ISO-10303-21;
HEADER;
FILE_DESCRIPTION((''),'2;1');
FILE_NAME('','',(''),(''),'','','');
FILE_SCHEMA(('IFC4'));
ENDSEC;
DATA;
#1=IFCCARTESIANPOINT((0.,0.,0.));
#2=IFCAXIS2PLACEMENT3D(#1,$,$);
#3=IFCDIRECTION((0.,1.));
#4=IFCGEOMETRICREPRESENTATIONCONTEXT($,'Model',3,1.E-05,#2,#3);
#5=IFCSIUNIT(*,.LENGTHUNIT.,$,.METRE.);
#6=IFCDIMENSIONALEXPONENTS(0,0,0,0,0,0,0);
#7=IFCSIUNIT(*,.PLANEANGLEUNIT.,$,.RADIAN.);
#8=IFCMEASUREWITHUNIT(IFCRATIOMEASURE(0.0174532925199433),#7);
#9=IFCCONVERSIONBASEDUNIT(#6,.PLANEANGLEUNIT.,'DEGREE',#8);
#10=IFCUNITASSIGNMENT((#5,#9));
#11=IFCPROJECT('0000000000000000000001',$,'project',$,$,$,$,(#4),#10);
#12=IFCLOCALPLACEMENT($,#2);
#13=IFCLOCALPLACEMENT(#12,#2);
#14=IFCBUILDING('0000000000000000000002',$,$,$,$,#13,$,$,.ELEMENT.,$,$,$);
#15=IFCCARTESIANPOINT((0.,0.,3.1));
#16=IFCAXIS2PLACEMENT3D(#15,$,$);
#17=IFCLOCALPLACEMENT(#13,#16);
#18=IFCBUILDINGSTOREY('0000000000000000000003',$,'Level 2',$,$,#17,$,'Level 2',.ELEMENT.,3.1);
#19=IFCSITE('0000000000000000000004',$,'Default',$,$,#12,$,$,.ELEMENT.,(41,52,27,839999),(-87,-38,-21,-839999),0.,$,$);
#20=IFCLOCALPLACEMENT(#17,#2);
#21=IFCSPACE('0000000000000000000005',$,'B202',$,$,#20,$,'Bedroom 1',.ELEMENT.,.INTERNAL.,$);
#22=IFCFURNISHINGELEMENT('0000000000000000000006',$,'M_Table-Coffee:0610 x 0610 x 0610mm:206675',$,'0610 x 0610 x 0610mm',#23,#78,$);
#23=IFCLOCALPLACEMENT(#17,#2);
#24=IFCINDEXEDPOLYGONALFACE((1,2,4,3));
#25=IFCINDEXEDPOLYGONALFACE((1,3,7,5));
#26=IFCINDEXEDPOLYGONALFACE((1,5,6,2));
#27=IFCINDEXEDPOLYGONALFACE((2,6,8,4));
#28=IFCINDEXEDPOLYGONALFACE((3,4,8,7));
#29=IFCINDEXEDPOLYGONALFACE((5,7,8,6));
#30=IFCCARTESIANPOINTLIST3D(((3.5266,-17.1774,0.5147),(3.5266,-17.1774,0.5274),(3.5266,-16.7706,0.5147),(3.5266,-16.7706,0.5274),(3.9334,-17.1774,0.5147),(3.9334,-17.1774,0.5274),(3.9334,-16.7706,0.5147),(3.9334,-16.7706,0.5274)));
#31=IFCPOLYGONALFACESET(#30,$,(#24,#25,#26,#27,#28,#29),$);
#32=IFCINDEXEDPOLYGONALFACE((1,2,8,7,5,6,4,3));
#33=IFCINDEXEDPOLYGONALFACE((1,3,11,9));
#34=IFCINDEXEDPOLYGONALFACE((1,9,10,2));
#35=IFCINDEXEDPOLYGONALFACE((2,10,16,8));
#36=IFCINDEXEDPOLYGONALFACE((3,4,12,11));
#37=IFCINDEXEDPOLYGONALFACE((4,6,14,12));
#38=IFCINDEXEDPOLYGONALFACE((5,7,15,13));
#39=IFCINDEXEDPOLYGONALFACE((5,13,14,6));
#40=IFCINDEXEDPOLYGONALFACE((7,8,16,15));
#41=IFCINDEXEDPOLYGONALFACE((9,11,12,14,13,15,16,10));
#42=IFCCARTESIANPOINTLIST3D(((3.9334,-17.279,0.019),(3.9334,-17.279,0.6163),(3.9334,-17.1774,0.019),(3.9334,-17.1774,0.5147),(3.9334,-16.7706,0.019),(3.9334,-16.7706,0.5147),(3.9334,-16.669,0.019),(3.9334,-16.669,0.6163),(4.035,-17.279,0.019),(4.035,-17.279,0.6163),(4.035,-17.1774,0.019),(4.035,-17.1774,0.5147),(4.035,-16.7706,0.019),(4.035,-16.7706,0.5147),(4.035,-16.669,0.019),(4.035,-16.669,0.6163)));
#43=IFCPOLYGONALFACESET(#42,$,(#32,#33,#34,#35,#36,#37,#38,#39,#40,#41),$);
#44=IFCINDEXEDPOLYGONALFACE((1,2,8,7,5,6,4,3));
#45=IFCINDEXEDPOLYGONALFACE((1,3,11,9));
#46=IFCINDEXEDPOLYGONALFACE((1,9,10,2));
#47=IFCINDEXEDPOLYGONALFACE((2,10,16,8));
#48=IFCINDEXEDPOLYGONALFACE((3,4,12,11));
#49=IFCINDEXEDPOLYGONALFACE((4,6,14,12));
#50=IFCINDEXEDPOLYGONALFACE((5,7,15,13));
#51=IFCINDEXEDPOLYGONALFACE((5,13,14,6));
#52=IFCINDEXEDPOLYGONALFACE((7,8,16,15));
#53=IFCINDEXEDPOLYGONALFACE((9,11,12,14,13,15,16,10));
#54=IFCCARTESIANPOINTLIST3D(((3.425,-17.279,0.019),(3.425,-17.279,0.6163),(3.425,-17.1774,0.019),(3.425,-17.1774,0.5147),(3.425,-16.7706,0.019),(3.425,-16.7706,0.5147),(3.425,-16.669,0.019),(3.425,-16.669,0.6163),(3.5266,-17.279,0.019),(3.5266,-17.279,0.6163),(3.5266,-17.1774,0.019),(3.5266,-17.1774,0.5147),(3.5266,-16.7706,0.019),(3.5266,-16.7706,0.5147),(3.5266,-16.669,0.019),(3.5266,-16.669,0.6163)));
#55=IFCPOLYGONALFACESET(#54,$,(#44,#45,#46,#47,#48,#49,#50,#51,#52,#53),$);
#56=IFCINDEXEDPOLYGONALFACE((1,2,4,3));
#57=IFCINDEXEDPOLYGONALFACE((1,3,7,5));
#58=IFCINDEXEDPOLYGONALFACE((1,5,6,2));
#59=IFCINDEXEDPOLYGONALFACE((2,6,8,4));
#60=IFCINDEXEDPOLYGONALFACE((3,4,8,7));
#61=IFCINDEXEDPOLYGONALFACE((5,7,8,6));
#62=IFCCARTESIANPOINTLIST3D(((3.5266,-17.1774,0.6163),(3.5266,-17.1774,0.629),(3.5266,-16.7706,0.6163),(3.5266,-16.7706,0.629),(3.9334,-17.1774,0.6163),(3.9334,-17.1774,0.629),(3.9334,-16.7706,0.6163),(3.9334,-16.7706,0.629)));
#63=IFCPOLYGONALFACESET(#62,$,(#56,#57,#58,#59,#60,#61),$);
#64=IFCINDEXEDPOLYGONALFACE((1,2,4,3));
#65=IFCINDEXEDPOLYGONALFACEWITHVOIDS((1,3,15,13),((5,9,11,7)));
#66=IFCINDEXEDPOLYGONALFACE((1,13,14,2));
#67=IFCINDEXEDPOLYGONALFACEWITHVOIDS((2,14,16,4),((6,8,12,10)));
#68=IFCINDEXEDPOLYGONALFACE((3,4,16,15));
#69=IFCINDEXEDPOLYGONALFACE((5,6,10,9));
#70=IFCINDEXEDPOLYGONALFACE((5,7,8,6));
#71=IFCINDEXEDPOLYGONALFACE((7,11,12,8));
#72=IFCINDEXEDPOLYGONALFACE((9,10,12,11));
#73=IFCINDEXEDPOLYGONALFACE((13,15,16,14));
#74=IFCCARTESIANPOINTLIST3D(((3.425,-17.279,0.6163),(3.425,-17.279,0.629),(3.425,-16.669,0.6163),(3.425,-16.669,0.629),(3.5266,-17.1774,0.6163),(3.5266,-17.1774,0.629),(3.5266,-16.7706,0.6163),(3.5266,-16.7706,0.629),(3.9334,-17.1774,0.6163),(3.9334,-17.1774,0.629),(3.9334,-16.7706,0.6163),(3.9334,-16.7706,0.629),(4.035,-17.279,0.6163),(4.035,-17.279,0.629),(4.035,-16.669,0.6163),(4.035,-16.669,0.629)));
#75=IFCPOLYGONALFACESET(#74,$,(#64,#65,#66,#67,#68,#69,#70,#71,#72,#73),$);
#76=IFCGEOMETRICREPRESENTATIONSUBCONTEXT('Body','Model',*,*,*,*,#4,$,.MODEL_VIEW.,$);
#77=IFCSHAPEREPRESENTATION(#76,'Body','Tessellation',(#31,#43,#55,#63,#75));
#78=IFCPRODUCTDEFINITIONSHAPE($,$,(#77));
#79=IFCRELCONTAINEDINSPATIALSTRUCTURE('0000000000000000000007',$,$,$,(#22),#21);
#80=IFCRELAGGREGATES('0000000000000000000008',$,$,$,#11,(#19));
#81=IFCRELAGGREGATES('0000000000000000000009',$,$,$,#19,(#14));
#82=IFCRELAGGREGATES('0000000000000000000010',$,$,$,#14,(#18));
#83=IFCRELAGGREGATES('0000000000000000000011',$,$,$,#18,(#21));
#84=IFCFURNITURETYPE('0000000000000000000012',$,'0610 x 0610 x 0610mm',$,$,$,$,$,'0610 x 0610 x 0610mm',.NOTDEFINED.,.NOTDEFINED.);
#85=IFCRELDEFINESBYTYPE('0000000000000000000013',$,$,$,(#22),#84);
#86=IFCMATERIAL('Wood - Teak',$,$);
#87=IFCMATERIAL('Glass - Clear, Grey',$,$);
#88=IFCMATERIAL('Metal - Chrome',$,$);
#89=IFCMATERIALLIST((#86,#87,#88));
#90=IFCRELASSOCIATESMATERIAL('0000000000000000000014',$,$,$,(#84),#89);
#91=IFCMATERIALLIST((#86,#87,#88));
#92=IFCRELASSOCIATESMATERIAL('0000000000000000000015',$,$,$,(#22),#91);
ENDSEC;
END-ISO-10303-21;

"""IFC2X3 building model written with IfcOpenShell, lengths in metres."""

from ifc_helpers import new_model, entity, si_unit, converted_unit, direction, frame, origin, origin_2d_with_axis, place, context, subcontext, project, spatial, polyline, rectangle, outline, extrude, source, transform, mapped, material, material_list, type_object, type_shapes, element, save


model = new_model("IFC2X3")

# Units and contexts
model_context = context("Model", 3, precision=1e-05, world=origin(), true_north=direction((0.0, 1.0)))
body_context = subcontext(model_context, "Body", "Model", "MODEL_VIEW")
ifc_project = project(units=[si_unit("LENGTHUNIT", "METRE"), converted_unit("PLANEANGLEUNIT", "DEGREE", entity("IfcRatioMeasure", 0.0174532925199433), si_unit("PLANEANGLEUNIT", "RADIAN"), dimensions=[0, 0, 0, 0, 0, 0, 0])], contexts=[model_context])

# Site, building, storey
site_placement = place(None, origin())
site = spatial("IfcSite", under=ifc_project, at=site_placement, Name="Default", CompositionType="ELEMENT", RefLatitude=(41, 52, 27, 839999), RefLongitude=(-87, -38, -21, -839999), RefElevation=0.0)
building_placement = place(site_placement, origin())
building = spatial("IfcBuilding", under=site, at=building_placement, CompositionType="ELEMENT")
storey_placement = place(building_placement, frame((0.0, 0.0, 3.1)))
storey = spatial("IfcBuildingStorey", under=building, at=storey_placement, Name="Level 2", LongName="Level 2", CompositionType="ELEMENT", Elevation=3.1)

# Shared definitions
space_placement = place(storey_placement, origin())
space = spatial("IfcSpace", under=storey, at=space_placement, Name="B202", LongName="Bedroom 1", CompositionType="ELEMENT", InteriorOrExteriorSpace="INTERNAL")

# Furnishing element
ifc_material_1 = material(Name="Wood - Teak")
ifc_material_2 = material(Name="Glass - Clear, Grey")
ifc_material_3 = material(Name="Metal - Chrome")
ifc_material_list_1 = material_list([ifc_material_1, ifc_material_2, ifc_material_3])
ifc_material_list_2 = material_list([ifc_material_1, ifc_material_2, ifc_material_3])
furniture_type_1 = type_object("IfcFurnitureType", Name="0610 x 0610 x 0610mm", ElementType="0610 x 0610 x 0610mm", AssemblyPlace="NOTDEFINED", material=ifc_material_list_2)
shared_shape_1 = source(origin(), body_context, "Body", "SweptSolid", [
    extrude(rectangle(XDim=0.4068, YDim=0.4068, at=origin_2d_with_axis()), frame((0.0183, 0.0952, 0.4957), z_axis=(0.0, 0.0, 1.0), x_axis=(-1.0, 0.0, 0.0)), (0.0, 0.0, 1.0), 0.0127),
    extrude(outline(polyline([(-0.2732, -0.305), (0.324, -0.305), (0.324, 0.305), (-0.2732, 0.305), (-0.2732, 0.2034), (0.2225, 0.2034), (0.2225, -0.2034), (-0.2732, -0.2034), (-0.2732, -0.305)])), frame((0.2217, 0.0952, 0.2732), z_axis=(1.0, 0.0, 0.0), x_axis=(0.0, 0.0, 1.0)), (0.0, 0.0, 1.0), 0.1016),
    extrude(outline(polyline([(-0.305, -0.3241), (0.305, -0.3241), (0.305, 0.2733), (0.2034, 0.2733), (0.2034, -0.2224), (-0.2034, -0.2224), (-0.2034, 0.2733), (-0.305, 0.2733), (-0.305, -0.3241)])), frame((-0.2867, 0.0952, 0.2733), z_axis=(1.0, 0.0, 0.0), x_axis=(0.0, -1.0, 0.0)), (0.0, 0.0, 1.0), 0.1016),
    extrude(rectangle(XDim=0.4068, YDim=0.4068, at=origin_2d_with_axis()), frame((0.0183, 0.0952, 0.5973), z_axis=(0.0, 0.0, 1.0), x_axis=(-1.0, 0.0, 0.0)), (0.0, 0.0, 1.0), 0.0127),
    extrude(outline(polyline([(-0.305, -0.305), (0.305, -0.305), (0.305, 0.305), (-0.305, 0.305), (-0.305, -0.305)]), holes=[polyline([(-0.2034, -0.2034), (-0.2034, 0.2034), (0.2034, 0.2034), (0.2034, -0.2034), (-0.2034, -0.2034)])]), frame((0.0183, 0.0952, 0.5973), z_axis=(0.0, 0.0, 1.0), x_axis=(-1.0, 0.0, 0.0)), (0.0, 0.0, 1.0), 0.0127),
])
type_shapes(furniture_type_1, [shared_shape_1])
furnishing_1_placement = place(space_placement, frame((3.7117, -17.0692, 0.019)))
element("IfcFurnishingElement", 1, at=furnishing_1_placement, inside=space, type_object=furniture_type_1, material=ifc_material_list_1, Name="M_Table-Coffee:0610 x 0610 x 0610mm:206675", ObjectType="0610 x 0610 x 0610mm", context=body_context, shape_type="MappedRepresentation", body=[
    mapped(shared_shape_1, transform((0.0, 0.0, 0.0), scale=1.0)),
])

save(model, "model.ifc")
